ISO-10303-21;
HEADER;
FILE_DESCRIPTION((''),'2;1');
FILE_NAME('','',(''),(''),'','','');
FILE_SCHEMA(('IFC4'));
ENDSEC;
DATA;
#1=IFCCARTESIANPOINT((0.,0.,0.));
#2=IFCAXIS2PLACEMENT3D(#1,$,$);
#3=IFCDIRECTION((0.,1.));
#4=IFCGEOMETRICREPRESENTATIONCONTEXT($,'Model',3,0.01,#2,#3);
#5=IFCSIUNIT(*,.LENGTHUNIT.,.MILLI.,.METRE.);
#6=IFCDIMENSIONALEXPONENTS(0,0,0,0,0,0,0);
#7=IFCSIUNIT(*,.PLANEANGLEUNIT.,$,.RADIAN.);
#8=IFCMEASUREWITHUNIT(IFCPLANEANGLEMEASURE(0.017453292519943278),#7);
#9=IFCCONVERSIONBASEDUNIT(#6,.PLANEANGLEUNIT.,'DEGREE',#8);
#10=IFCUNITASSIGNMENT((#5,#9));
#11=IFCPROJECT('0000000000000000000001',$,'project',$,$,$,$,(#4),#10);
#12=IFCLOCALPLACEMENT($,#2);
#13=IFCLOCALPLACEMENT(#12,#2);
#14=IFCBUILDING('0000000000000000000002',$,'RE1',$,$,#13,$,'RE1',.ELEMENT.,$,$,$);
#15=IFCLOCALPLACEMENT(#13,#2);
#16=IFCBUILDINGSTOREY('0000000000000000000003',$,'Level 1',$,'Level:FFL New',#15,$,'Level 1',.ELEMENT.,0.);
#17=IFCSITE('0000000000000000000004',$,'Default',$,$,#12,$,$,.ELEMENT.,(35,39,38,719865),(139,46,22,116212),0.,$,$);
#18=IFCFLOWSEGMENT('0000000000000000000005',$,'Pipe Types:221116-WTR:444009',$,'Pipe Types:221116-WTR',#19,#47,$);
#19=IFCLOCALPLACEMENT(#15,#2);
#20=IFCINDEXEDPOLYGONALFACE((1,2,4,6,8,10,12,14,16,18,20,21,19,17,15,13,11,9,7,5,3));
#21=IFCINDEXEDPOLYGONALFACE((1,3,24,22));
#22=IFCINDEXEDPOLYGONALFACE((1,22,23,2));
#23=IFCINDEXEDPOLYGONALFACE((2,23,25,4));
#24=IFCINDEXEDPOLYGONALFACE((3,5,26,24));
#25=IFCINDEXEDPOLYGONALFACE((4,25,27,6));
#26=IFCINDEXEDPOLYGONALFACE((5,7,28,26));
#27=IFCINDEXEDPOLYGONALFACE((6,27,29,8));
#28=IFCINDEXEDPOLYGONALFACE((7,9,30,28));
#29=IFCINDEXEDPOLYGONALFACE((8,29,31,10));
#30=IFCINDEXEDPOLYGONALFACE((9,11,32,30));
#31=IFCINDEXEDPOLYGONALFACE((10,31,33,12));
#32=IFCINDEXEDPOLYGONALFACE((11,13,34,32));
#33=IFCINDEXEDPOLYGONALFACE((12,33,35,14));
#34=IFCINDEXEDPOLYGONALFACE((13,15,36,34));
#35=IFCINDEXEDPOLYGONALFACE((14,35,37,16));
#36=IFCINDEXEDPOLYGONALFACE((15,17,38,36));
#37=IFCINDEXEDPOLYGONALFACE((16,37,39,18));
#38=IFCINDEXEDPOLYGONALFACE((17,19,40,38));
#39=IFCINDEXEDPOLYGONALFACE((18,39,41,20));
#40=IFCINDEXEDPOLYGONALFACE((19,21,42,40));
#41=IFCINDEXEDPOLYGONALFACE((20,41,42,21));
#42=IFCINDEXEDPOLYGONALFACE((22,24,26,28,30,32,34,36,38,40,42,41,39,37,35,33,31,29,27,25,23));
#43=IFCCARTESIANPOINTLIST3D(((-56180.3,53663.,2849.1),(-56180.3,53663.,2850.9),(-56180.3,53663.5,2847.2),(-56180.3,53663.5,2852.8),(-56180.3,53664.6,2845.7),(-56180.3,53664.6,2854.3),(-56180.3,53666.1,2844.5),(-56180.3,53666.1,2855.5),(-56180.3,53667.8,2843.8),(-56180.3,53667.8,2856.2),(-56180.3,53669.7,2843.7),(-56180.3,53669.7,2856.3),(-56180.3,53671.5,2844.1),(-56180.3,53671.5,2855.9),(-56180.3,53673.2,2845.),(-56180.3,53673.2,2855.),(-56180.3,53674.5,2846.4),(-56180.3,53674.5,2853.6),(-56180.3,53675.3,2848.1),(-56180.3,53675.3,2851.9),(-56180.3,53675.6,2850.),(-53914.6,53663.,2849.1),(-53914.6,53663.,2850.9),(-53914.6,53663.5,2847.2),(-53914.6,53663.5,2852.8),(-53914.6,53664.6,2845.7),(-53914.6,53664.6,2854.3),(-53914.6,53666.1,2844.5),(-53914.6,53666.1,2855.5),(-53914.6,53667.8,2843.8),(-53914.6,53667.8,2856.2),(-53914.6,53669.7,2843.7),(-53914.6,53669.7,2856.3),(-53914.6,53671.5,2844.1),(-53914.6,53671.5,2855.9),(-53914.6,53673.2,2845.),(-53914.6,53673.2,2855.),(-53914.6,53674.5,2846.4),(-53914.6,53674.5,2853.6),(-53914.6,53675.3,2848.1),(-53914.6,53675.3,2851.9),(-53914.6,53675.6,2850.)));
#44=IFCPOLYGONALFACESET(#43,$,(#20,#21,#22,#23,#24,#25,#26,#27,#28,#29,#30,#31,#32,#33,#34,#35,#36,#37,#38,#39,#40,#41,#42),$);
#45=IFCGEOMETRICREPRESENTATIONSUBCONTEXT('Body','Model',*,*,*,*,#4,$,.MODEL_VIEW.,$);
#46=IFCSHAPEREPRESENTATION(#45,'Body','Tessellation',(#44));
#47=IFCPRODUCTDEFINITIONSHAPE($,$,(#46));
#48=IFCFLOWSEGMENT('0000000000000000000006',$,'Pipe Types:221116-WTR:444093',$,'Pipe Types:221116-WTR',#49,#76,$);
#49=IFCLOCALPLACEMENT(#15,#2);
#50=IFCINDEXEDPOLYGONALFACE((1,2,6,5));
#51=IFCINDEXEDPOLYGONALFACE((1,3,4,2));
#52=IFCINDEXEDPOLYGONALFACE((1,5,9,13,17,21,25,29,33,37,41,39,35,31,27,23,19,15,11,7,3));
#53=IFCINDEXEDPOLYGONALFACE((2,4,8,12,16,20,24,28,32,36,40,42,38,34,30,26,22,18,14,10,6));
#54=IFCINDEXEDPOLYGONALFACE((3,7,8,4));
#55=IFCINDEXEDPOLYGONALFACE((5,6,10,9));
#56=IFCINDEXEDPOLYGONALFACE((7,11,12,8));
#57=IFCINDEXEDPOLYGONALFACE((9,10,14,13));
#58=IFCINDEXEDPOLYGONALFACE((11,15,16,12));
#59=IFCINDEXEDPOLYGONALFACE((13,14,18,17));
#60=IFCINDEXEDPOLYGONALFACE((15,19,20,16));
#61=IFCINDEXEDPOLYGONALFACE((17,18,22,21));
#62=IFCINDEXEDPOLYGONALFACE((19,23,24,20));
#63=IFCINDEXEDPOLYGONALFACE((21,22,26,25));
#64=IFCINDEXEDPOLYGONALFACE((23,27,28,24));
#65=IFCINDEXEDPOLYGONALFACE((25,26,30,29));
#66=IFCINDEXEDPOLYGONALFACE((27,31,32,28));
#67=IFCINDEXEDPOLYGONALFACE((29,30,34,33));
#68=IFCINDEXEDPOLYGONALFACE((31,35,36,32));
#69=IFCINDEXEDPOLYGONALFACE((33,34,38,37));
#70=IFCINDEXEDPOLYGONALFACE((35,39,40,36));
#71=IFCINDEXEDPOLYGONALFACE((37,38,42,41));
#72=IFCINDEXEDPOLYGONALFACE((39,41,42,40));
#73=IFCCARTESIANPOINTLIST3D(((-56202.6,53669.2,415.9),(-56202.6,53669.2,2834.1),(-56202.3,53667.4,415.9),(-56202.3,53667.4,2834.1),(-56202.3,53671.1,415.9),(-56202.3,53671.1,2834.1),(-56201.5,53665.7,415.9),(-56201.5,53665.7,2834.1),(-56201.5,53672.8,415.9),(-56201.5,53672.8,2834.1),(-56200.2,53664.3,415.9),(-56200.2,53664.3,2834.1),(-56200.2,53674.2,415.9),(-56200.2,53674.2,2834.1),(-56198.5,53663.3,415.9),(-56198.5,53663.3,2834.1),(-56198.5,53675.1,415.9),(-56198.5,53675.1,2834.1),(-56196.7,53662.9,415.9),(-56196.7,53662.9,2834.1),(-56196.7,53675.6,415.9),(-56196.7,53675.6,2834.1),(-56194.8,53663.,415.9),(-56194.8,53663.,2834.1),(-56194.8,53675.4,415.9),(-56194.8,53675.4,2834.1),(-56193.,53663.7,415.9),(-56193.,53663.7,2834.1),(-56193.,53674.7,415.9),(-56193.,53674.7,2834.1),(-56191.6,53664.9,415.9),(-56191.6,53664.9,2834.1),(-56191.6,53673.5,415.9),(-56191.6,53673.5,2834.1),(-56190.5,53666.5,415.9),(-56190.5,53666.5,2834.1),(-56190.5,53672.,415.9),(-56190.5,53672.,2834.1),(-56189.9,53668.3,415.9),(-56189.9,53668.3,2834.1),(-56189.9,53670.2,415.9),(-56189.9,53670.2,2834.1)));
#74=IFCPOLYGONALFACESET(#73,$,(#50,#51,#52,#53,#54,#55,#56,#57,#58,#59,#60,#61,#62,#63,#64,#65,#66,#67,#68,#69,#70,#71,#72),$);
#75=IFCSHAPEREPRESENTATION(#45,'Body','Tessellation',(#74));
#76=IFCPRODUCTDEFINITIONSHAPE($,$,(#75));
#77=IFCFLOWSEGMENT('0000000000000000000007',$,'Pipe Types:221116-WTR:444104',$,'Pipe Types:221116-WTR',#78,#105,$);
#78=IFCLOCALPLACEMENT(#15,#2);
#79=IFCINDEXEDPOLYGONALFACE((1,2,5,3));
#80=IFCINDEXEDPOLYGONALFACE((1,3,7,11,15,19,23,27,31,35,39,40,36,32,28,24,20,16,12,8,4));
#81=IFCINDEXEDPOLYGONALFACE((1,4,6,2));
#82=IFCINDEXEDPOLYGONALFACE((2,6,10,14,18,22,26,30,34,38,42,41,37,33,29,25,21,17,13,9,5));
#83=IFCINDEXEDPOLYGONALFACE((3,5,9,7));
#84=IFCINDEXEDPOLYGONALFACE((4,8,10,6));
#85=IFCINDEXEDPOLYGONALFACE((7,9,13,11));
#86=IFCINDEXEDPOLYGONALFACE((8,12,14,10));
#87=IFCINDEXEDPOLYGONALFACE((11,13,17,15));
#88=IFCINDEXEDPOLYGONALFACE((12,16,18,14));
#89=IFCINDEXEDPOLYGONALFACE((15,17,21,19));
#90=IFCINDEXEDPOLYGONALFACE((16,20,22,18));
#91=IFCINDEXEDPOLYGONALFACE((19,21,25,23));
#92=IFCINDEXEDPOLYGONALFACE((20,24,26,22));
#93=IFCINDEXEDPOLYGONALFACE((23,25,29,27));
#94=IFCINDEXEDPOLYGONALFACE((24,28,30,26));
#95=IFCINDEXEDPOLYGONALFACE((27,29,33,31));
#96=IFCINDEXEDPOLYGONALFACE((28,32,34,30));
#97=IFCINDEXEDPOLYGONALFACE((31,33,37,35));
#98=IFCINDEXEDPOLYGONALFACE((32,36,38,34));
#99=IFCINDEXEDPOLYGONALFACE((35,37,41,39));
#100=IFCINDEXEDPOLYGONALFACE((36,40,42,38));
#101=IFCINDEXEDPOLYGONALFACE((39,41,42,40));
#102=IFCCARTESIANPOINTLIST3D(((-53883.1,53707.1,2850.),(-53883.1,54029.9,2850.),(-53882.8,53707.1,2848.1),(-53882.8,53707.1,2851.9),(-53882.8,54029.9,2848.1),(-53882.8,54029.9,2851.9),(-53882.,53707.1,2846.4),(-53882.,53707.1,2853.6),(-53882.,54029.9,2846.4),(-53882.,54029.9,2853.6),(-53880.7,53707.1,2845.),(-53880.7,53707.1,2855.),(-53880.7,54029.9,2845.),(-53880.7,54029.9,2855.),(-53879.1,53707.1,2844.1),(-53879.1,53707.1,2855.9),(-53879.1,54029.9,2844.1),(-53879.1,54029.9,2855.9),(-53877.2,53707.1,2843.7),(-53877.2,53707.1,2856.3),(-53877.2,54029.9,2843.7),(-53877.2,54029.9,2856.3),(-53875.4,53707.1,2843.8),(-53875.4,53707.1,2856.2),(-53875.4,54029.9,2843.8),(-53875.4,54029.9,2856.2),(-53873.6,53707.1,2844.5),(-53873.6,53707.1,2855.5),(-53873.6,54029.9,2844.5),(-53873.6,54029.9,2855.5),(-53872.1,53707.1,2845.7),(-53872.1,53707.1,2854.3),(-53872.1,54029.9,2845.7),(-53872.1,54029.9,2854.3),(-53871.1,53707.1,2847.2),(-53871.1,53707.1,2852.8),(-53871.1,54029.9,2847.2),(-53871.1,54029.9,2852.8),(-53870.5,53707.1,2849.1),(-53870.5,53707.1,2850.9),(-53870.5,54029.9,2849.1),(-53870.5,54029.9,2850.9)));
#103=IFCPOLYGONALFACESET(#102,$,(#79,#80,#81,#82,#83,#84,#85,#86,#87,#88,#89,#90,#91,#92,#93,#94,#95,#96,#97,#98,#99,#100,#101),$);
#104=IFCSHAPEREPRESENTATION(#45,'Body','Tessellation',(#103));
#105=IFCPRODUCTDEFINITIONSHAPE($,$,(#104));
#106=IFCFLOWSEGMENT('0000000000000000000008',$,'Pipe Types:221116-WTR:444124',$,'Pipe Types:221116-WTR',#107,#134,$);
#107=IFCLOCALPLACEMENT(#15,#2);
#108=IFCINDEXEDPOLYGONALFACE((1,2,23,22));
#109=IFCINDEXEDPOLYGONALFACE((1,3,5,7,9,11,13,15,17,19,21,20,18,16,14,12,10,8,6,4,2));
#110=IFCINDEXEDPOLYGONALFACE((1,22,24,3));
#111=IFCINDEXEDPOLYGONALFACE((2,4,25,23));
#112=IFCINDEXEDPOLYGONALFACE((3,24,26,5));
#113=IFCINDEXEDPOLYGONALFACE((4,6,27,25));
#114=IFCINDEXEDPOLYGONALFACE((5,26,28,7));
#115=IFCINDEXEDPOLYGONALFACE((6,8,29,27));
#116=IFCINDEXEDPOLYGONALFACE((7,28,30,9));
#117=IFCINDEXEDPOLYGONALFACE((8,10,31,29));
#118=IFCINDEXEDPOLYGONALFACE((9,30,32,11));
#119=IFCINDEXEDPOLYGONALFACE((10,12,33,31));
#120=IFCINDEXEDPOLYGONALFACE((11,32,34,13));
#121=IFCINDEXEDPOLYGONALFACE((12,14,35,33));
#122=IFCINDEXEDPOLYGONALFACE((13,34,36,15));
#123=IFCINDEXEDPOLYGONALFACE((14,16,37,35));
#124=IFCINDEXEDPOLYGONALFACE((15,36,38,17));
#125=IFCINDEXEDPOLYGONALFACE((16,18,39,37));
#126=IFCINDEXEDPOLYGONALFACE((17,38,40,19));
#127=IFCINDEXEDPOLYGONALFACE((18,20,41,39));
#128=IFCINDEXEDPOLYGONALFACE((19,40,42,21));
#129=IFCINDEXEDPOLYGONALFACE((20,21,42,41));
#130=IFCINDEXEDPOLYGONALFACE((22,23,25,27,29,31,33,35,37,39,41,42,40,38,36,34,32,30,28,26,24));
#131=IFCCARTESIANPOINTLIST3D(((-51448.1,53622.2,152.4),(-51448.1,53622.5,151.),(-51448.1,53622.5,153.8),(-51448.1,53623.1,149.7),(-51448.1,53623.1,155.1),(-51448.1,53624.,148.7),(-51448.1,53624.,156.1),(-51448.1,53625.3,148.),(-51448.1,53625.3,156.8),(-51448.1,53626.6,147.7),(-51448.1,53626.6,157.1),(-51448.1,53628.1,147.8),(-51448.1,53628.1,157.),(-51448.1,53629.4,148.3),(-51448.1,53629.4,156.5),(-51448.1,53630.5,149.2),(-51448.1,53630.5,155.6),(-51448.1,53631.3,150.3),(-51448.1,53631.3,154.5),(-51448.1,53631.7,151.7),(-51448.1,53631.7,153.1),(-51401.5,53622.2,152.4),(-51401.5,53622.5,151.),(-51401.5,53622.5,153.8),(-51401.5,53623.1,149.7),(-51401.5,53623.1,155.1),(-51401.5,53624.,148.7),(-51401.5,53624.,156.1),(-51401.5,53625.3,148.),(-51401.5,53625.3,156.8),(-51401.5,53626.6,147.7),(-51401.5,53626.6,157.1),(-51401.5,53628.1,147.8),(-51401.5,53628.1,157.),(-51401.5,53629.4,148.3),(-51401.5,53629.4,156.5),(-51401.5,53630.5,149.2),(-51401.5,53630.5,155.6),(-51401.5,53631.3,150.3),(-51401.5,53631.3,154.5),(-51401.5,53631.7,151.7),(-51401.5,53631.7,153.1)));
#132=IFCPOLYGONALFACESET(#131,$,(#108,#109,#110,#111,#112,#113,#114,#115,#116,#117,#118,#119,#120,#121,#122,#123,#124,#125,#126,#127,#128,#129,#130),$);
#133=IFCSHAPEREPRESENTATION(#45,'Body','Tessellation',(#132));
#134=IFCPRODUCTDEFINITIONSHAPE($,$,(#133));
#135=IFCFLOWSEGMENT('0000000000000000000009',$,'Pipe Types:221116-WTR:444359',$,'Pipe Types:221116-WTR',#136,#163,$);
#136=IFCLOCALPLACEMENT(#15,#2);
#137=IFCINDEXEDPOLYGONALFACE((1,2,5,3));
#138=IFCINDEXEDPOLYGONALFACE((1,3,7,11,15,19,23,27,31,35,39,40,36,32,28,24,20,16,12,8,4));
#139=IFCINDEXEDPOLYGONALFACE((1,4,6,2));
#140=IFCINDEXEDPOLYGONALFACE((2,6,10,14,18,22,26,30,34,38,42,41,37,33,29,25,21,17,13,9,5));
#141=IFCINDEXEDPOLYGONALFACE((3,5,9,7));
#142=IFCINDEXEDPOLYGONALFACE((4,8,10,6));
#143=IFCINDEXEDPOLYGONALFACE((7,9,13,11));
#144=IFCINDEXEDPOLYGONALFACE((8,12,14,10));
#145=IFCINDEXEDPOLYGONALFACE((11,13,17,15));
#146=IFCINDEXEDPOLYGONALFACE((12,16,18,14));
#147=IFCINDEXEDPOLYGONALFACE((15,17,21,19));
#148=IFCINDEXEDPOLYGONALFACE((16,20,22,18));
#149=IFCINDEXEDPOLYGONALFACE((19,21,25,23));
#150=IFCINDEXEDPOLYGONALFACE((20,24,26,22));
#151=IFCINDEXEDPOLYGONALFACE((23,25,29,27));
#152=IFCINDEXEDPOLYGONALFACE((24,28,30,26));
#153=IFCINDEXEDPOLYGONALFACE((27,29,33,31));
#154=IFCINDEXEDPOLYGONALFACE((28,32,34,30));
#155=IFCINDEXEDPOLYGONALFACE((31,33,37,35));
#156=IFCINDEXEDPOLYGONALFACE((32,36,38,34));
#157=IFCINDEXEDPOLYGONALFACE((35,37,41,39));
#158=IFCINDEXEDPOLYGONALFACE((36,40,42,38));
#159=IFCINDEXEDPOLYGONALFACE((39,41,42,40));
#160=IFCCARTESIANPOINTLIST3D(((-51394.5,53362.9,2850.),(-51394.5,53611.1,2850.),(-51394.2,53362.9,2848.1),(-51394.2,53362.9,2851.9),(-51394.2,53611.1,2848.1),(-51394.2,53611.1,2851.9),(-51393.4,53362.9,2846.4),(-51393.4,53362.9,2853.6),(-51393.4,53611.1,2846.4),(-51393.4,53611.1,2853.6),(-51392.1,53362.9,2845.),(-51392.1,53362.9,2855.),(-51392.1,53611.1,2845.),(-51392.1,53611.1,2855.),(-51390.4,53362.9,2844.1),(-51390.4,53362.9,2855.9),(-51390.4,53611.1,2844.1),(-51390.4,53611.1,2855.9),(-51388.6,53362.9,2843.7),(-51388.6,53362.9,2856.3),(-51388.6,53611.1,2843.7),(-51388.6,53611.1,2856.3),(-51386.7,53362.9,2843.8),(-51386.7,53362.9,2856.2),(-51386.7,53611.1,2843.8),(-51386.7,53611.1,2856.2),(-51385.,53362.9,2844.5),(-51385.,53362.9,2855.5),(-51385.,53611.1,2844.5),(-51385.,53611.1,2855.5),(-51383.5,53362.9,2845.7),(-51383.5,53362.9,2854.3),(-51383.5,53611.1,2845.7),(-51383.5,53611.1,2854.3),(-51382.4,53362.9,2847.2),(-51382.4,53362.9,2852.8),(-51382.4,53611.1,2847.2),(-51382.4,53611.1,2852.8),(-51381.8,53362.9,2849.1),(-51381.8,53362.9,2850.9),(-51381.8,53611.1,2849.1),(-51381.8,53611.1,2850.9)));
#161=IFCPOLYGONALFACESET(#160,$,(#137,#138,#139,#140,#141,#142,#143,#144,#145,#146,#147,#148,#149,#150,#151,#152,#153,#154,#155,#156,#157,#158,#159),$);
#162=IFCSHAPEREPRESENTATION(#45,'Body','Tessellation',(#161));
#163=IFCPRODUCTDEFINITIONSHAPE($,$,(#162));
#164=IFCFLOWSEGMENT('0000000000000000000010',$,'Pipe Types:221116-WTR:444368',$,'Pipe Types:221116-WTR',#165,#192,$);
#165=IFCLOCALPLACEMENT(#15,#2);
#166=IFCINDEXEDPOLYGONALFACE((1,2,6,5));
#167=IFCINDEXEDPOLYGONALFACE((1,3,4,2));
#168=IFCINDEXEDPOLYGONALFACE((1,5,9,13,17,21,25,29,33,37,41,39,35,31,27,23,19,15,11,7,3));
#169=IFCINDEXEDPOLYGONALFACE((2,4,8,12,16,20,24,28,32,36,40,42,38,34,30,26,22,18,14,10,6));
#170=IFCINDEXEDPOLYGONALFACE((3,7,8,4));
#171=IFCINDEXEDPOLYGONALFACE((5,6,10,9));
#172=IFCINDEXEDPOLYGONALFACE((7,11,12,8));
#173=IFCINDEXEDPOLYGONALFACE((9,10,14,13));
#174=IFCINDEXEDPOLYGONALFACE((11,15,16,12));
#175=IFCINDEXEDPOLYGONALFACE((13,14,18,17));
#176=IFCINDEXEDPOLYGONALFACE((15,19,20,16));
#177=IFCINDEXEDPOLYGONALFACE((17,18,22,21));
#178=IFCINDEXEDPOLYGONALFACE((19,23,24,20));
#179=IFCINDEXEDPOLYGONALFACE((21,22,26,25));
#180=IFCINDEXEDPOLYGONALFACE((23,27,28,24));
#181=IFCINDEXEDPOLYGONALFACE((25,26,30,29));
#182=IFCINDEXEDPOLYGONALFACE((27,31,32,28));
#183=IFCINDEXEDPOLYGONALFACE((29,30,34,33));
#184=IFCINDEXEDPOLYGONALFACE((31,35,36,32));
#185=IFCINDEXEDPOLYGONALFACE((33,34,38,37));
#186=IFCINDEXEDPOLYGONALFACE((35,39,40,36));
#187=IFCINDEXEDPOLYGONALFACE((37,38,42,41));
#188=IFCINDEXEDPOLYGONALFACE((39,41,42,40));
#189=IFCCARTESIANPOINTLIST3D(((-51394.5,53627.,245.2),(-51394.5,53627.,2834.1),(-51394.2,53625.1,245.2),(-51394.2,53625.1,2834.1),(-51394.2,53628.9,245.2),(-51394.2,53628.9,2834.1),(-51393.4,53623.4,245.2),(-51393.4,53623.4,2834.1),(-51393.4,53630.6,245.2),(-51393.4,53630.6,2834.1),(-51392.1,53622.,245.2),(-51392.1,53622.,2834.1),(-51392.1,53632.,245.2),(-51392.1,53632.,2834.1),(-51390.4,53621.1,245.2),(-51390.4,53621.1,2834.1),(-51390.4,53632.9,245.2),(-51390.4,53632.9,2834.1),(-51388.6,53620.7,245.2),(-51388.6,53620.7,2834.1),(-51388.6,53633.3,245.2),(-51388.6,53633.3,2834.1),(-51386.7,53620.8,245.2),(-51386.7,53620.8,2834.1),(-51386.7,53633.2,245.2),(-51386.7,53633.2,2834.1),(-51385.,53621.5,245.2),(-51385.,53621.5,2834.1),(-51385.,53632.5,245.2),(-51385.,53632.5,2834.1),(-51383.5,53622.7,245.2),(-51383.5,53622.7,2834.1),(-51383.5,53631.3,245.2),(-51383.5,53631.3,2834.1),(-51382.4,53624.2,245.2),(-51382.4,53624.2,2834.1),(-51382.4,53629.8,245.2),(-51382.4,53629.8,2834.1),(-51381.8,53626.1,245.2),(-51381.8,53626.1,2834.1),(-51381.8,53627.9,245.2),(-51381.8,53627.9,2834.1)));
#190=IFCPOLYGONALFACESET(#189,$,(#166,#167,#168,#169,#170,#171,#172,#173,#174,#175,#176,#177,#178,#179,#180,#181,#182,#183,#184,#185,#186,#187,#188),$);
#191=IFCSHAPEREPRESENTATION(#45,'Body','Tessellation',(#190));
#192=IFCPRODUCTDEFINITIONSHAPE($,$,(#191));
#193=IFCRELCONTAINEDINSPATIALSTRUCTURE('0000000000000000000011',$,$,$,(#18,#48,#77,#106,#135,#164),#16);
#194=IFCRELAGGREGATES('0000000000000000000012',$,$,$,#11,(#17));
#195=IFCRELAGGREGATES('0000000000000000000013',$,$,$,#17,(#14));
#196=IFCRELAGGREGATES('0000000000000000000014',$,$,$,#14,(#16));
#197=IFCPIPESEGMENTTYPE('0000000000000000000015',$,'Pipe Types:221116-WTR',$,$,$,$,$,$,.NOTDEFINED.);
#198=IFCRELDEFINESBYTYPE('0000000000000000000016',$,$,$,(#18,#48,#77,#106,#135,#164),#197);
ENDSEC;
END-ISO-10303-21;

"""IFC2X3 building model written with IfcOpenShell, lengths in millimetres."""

from ifc_helpers import new_model, entity, si_unit, converted_unit, direction, frame, frame_2d, origin, origin_2d_with_axis, place, context, subcontext, project, spatial, circle, extrude, type_object, element, save


model = new_model("IFC2X3")

# Units and contexts
model_context = context("Model", 3, precision=0.01, world=origin(), true_north=direction((0.0, 1.0)))
body_context = subcontext(model_context, "Body", "Model", "MODEL_VIEW")
ifc_project = project(units=[si_unit("LENGTHUNIT", "METRE", prefix="MILLI"), converted_unit("PLANEANGLEUNIT", "DEGREE", entity("IfcPlaneAngleMeasure", 0.017453292519943278), si_unit("PLANEANGLEUNIT", "RADIAN"), dimensions=[0, 0, 0, 0, 0, 0, 0])], contexts=[model_context])

# Site, building, storey
site_placement = place(None, origin())
site = spatial("IfcSite", under=ifc_project, at=site_placement, Name="Default", CompositionType="ELEMENT", RefLatitude=(35, 39, 38, 719865), RefLongitude=(139, 46, 22, 116212), RefElevation=0.0)
building_placement = place(site_placement, origin())
building = spatial("IfcBuilding", under=site, at=building_placement, Name="RE1", LongName="RE1", CompositionType="ELEMENT")
storey_placement = place(building_placement, origin())
storey = spatial("IfcBuildingStorey", under=building, at=storey_placement, Name="Level 1", ObjectType="Level:FFL New", LongName="Level 1", CompositionType="ELEMENT", Elevation=0.0)

# Flow segments
pipe_segment_type_1 = type_object("IfcPipeSegmentType", Name="Pipe Types:221116-WTR", PredefinedType="NOTDEFINED")
flow_segment_1_placement = place(storey_placement, origin())
element("IfcFlowSegment", 1, at=flow_segment_1_placement, inside=storey, type_object=pipe_segment_type_1, Name="Pipe Types:221116-WTR:444009", ObjectType="Pipe Types:221116-WTR", context=body_context, shape_type="SweptSolid", body=[
    extrude(circle(Radius=6.3, at=origin_2d_with_axis()), frame((-56180.3, 53669.2, 2850.0), z_axis=(1.0, 0.0, 0.0), x_axis=(0.0, 1.0, 0.0)), (0.0, 0.0, 1.0), 2265.7),
])
flow_segment_2_placement = place(storey_placement, origin())
element("IfcFlowSegment", 2, at=flow_segment_2_placement, inside=storey, type_object=pipe_segment_type_1, Name="Pipe Types:221116-WTR:444093", ObjectType="Pipe Types:221116-WTR", context=body_context, shape_type="SweptSolid", body=[
    extrude(circle(Radius=6.3, at=origin_2d_with_axis()), frame((-56196.2, 53669.2, 415.9), z_axis=(0.0, 0.0, 1.0), x_axis=(-1.0, 0.0, 0.0)), (0.0, 0.0, 1.0), 2418.2),
])
flow_segment_3_placement = place(storey_placement, origin())
element("IfcFlowSegment", 3, at=flow_segment_3_placement, inside=storey, type_object=pipe_segment_type_1, Name="Pipe Types:221116-WTR:444104", ObjectType="Pipe Types:221116-WTR", context=body_context, shape_type="SweptSolid", body=[
    extrude(circle(Radius=6.3, at=frame_2d((0.0, 0.0), x_axis=(1.0, 0.0))), frame((-53876.8, 53707.1, 2850.0), z_axis=(0.0, 1.0, 0.0), x_axis=(-1.0, 0.0, 0.0)), (0.0, 0.0, 1.0), 322.9),
])
flow_segment_4_placement = place(storey_placement, origin())
element("IfcFlowSegment", 4, at=flow_segment_4_placement, inside=storey, type_object=pipe_segment_type_1, Name="Pipe Types:221116-WTR:444124", ObjectType="Pipe Types:221116-WTR", context=body_context, shape_type="SweptSolid", body=[
    extrude(circle(Radius=4.8, at=origin_2d_with_axis()), frame((-51448.1, 53627.0, 152.4), z_axis=(1.0, 0.0, 0.0), x_axis=(0.0, -1.0, 0.0)), (0.0, 0.0, 1.0), 46.6),
])
flow_segment_5_placement = place(storey_placement, origin())
element("IfcFlowSegment", 5, at=flow_segment_5_placement, inside=storey, type_object=pipe_segment_type_1, Name="Pipe Types:221116-WTR:444359", ObjectType="Pipe Types:221116-WTR", context=body_context, shape_type="SweptSolid", body=[
    extrude(circle(Radius=6.3, at=frame_2d((0.0, 0.0), x_axis=(1.0, 0.0))), frame((-51388.1, 53362.9, 2850.0), z_axis=(0.0, 1.0, 0.0), x_axis=(-1.0, 0.0, 0.0)), (0.0, 0.0, 1.0), 248.2),
])
flow_segment_6_placement = place(storey_placement, origin())
element("IfcFlowSegment", 6, at=flow_segment_6_placement, inside=storey, type_object=pipe_segment_type_1, Name="Pipe Types:221116-WTR:444368", ObjectType="Pipe Types:221116-WTR", context=body_context, shape_type="SweptSolid", body=[
    extrude(circle(Radius=6.3, at=origin_2d_with_axis()), frame((-51388.1, 53627.0, 245.2), z_axis=(0.0, 0.0, 1.0), x_axis=(-1.0, 0.0, 0.0)), (0.0, 0.0, 1.0), 2588.9),
])

save(model, "model.ifc")
